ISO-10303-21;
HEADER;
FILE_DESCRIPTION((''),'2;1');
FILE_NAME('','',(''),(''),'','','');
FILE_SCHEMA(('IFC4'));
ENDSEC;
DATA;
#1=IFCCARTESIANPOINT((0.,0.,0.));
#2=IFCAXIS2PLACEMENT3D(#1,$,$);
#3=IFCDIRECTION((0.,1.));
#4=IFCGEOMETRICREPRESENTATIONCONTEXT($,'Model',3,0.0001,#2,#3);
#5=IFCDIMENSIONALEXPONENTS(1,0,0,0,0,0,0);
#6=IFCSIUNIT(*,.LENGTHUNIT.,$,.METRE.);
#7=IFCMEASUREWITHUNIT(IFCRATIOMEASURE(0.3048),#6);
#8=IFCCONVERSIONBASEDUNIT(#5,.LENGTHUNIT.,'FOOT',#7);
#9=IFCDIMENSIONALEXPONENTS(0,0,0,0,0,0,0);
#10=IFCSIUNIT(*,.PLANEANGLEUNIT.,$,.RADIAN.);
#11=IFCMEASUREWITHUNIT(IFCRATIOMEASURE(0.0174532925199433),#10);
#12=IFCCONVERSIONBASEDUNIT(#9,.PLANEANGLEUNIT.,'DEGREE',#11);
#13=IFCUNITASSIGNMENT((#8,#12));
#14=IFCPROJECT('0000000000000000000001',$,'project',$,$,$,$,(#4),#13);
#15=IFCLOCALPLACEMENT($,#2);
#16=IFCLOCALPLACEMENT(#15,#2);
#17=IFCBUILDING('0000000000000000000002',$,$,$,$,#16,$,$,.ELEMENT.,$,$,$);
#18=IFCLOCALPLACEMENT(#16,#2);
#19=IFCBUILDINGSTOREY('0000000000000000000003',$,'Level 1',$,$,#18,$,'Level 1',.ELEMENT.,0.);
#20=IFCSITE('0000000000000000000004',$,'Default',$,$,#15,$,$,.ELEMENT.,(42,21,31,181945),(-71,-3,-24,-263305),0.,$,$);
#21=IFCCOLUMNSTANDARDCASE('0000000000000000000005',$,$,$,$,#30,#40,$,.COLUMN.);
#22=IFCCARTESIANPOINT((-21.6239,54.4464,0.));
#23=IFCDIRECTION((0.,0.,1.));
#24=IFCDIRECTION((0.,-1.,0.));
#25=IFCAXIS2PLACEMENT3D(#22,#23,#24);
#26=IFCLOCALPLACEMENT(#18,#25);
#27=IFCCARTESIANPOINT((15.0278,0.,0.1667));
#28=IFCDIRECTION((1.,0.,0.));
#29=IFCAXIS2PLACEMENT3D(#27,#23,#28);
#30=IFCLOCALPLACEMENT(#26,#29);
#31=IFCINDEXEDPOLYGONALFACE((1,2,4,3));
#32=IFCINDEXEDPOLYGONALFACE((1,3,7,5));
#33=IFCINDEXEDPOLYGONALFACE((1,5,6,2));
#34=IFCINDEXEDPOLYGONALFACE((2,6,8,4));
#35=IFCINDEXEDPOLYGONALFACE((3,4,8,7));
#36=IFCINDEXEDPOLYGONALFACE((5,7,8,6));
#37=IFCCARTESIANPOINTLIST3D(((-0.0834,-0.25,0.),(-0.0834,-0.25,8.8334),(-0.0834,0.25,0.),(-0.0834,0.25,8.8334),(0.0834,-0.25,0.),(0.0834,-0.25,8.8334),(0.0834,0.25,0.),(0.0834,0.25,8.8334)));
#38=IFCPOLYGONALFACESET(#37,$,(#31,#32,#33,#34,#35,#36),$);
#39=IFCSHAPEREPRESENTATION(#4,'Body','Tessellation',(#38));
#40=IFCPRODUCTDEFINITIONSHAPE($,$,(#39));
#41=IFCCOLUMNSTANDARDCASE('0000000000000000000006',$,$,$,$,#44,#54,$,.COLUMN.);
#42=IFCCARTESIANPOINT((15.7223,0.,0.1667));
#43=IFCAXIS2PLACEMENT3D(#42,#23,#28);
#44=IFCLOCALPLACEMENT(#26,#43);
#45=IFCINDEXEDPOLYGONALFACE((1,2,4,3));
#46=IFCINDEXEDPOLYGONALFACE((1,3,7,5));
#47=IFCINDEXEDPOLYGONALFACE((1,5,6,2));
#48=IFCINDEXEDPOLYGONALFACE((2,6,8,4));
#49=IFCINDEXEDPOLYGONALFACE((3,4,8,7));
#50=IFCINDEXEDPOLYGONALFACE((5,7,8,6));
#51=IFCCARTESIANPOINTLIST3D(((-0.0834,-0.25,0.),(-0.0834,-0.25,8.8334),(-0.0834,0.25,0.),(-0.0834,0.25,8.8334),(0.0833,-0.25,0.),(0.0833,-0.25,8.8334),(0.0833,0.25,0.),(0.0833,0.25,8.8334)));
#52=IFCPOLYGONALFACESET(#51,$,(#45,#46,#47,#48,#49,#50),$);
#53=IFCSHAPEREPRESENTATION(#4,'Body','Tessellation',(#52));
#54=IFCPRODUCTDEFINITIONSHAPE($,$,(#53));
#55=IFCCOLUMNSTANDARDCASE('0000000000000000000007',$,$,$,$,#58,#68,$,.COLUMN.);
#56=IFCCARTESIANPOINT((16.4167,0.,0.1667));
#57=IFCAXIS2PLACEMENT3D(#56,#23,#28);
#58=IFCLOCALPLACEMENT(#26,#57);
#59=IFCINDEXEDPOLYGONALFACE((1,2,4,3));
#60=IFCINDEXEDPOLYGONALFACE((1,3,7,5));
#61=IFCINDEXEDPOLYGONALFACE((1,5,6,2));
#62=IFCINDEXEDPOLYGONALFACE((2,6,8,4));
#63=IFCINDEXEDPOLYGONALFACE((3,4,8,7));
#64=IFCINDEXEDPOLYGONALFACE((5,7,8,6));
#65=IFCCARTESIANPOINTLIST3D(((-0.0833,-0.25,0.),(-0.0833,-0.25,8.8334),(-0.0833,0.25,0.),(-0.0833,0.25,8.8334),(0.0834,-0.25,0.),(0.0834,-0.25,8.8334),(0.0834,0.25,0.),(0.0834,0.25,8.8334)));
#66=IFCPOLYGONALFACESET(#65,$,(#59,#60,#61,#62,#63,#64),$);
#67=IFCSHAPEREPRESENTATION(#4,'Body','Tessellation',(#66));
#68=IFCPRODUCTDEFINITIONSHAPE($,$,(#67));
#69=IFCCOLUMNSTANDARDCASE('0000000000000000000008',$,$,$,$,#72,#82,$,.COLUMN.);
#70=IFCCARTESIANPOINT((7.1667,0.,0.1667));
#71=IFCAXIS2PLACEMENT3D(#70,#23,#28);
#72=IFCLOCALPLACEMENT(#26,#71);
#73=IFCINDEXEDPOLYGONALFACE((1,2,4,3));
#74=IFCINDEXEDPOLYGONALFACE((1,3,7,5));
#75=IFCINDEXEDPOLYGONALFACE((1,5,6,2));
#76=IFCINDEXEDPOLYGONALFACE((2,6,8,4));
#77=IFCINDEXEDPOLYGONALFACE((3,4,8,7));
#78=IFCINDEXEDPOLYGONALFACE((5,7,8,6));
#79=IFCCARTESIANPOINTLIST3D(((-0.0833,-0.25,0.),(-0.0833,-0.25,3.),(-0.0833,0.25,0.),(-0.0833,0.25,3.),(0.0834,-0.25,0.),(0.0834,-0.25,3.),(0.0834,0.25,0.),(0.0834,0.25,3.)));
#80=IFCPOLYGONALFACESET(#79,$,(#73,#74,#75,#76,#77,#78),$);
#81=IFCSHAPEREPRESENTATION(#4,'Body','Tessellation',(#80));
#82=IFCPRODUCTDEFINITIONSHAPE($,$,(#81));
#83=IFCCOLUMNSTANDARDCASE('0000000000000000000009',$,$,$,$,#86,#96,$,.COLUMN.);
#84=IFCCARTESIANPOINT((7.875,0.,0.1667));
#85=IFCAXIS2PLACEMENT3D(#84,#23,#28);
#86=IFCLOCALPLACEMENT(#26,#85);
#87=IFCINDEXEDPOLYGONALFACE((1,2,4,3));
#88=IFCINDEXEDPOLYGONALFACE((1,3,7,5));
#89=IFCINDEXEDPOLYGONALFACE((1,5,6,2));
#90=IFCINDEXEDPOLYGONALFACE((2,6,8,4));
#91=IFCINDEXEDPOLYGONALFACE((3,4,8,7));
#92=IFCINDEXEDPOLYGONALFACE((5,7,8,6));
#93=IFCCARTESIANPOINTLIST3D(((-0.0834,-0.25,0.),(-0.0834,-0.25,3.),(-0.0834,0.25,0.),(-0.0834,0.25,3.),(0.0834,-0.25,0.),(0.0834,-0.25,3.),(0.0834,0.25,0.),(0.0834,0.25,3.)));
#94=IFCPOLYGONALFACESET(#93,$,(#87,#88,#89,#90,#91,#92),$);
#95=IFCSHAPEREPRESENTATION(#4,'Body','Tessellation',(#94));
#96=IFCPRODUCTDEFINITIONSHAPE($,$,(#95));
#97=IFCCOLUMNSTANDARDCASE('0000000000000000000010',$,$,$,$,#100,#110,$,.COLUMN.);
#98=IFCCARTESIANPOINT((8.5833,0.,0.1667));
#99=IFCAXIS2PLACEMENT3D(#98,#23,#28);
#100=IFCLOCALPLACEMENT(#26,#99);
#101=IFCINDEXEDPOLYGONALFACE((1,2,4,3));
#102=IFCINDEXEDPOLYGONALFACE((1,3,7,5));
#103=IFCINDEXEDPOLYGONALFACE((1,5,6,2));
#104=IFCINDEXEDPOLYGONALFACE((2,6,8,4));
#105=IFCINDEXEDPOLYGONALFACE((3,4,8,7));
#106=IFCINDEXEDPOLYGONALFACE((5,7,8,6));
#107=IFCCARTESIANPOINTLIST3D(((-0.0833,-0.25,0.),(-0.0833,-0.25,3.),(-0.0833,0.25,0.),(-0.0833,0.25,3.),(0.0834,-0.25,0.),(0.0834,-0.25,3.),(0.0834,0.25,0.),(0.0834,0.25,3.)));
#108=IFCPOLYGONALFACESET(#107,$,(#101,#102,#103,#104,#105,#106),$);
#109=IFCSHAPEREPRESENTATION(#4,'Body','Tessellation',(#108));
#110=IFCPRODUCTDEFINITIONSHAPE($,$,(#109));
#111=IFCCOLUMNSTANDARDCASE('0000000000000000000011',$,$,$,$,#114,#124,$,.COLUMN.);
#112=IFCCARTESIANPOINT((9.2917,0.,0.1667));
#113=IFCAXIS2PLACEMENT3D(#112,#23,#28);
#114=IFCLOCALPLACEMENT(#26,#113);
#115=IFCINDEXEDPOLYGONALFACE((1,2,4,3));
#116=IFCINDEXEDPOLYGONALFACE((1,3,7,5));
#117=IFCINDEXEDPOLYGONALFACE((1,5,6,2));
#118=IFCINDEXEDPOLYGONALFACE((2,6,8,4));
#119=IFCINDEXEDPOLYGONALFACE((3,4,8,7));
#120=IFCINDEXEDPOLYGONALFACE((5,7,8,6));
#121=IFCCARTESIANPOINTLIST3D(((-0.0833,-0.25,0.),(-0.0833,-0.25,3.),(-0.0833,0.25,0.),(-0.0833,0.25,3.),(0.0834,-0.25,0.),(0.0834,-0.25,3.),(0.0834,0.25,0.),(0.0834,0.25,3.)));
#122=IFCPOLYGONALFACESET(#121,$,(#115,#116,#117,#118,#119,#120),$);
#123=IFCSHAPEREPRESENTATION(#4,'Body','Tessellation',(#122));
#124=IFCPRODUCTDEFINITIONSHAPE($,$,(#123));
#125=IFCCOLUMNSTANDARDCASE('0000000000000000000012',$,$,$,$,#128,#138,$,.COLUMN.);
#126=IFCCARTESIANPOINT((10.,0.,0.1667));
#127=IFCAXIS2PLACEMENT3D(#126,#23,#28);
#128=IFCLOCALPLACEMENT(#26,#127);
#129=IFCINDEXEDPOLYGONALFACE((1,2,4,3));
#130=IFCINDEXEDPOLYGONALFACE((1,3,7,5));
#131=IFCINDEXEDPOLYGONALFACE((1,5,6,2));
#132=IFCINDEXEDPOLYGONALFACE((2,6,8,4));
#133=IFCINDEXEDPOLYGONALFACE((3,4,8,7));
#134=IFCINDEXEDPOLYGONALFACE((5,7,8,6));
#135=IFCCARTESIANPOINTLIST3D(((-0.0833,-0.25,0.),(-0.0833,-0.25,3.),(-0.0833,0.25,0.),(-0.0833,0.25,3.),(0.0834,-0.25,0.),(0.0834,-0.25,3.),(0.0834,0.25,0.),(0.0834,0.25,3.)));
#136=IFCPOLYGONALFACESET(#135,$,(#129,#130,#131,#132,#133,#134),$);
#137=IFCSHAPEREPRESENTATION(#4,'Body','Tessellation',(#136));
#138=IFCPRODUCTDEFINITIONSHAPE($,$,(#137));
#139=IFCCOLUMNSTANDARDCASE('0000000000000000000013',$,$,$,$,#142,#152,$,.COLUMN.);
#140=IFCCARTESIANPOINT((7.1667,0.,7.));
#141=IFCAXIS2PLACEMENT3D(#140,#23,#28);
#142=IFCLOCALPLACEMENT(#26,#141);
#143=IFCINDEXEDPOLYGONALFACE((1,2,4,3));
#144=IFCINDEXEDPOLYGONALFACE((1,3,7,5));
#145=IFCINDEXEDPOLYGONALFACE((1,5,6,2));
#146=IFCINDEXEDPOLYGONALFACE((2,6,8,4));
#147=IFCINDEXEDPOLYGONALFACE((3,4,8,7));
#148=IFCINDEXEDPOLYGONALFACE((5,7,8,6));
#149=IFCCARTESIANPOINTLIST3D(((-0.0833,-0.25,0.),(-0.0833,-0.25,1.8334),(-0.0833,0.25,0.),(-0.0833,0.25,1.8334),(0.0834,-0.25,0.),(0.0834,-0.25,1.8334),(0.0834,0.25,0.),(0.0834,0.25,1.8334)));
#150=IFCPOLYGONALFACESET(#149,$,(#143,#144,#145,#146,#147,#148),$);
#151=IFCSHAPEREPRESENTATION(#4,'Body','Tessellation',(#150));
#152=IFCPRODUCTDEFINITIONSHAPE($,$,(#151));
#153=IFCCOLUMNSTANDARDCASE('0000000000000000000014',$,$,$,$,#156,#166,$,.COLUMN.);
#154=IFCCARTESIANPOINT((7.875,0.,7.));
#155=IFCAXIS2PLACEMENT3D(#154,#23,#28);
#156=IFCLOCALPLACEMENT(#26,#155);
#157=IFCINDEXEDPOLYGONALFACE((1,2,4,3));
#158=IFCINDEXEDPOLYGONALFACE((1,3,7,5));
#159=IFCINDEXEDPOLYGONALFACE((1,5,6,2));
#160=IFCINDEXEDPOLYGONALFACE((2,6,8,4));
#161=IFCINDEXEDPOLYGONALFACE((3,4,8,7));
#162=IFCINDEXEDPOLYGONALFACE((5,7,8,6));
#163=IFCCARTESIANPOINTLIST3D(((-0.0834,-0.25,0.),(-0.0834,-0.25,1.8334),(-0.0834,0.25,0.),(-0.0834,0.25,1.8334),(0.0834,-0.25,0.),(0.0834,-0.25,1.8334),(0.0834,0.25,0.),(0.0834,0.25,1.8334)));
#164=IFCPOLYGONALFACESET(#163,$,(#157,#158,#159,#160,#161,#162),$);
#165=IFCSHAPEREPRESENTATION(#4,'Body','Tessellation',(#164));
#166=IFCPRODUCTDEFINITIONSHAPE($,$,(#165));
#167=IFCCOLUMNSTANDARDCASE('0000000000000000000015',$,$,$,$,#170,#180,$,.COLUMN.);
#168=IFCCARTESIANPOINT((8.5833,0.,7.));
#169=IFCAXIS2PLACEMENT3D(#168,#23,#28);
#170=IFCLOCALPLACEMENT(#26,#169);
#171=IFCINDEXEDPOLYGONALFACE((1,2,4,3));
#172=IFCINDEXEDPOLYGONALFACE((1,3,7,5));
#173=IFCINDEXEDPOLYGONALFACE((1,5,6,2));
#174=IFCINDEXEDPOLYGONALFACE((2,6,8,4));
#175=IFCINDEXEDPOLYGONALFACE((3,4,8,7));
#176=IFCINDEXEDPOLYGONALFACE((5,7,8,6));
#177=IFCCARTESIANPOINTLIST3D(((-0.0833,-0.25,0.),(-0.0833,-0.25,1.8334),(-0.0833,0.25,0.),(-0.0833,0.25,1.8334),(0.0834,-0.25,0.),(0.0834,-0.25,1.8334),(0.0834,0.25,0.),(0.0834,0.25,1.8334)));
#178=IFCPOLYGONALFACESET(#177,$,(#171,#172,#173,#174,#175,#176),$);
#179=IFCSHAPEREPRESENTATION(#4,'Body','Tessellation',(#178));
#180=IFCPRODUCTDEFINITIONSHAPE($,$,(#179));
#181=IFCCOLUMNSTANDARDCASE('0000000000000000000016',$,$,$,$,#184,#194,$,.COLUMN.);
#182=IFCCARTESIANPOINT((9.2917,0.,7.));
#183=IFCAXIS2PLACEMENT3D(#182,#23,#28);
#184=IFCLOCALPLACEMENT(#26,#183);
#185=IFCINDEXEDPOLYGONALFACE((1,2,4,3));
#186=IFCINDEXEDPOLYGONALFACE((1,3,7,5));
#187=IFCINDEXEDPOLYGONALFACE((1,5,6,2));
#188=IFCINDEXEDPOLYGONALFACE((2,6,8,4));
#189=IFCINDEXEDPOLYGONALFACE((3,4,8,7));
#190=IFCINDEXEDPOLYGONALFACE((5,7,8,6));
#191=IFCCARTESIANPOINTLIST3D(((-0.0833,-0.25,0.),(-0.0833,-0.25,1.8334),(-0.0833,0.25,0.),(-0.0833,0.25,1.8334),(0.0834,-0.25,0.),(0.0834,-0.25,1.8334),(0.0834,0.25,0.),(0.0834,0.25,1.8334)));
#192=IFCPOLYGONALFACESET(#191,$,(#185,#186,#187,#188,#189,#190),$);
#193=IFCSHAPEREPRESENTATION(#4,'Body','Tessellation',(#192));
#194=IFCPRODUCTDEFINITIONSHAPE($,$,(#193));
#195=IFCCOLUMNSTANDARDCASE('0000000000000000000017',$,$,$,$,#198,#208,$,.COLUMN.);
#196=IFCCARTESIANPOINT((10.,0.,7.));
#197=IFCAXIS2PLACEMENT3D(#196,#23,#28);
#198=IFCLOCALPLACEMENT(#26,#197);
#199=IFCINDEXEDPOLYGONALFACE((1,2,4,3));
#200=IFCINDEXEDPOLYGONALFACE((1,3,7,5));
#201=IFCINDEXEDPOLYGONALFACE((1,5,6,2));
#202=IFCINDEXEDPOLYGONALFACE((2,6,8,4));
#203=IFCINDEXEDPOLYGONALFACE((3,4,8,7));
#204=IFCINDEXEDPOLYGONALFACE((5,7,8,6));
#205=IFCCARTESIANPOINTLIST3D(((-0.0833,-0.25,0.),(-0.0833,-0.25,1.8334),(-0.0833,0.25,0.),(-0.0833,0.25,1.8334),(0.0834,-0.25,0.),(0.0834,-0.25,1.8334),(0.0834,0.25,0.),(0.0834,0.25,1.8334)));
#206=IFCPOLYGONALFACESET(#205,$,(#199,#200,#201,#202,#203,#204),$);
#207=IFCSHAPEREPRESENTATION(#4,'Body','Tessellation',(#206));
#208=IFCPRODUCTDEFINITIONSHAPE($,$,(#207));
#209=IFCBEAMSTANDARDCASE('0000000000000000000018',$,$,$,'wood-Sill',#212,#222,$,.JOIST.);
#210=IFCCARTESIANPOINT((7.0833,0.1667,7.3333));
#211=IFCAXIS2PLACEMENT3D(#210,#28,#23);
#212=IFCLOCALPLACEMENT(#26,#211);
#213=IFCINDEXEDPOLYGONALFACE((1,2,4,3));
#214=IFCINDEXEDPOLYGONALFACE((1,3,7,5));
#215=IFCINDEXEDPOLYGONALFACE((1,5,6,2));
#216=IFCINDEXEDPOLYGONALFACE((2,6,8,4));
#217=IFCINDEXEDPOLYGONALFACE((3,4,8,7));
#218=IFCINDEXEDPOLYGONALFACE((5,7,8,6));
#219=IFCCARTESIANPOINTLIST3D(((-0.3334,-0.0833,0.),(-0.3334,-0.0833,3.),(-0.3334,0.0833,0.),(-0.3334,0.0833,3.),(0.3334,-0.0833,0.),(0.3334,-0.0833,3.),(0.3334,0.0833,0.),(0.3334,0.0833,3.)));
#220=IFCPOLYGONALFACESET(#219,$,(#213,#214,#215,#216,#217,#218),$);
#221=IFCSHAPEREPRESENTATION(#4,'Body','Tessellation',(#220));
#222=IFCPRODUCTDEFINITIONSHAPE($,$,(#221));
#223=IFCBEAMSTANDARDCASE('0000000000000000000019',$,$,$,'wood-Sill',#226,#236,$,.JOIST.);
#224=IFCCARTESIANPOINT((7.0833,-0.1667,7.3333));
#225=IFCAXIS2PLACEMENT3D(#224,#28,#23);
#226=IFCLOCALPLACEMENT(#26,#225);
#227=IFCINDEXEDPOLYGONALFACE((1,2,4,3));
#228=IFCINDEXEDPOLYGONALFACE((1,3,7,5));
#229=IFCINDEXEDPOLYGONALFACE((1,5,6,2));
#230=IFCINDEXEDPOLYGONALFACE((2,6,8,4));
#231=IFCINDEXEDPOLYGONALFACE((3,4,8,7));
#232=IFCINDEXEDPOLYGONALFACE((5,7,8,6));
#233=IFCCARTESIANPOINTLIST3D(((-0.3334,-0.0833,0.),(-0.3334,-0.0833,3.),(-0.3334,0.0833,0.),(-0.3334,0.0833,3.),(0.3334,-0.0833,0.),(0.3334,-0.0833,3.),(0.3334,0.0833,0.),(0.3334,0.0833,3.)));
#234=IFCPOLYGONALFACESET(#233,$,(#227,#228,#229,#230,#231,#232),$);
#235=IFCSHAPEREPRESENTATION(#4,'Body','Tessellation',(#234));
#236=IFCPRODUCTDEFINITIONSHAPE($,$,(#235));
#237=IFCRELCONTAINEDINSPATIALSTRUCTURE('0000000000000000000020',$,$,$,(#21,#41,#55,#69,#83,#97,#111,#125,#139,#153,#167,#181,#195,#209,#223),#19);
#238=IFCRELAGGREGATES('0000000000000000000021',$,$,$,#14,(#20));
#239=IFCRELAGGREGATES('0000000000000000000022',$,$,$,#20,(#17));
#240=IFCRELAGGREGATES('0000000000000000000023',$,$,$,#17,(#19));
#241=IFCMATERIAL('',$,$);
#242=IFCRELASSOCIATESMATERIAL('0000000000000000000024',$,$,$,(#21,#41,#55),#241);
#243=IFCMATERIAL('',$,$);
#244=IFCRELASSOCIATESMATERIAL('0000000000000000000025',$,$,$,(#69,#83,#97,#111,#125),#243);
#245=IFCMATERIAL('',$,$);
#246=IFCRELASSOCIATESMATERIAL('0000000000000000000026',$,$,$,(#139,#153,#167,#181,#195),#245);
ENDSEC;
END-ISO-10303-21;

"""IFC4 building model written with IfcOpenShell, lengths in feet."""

from ifc_helpers import new_model, entity, si_unit, converted_unit, direction, frame, origin, origin_with_axes, place, context, project, spatial, rectangle, extrude, material, element, save


model = new_model("IFC4")

# Units and contexts
model_context = context("Model", 3, precision=0.0001, world=origin(), true_north=direction((0.0, 1.0)))
ifc_project = project(units=[converted_unit("LENGTHUNIT", "FOOT", entity("IfcRatioMeasure", 0.3048), si_unit("LENGTHUNIT", "METRE"), dimensions=[1, 0, 0, 0, 0, 0, 0]), converted_unit("PLANEANGLEUNIT", "DEGREE", entity("IfcRatioMeasure", 0.0174532925199433), si_unit("PLANEANGLEUNIT", "RADIAN"), dimensions=[0, 0, 0, 0, 0, 0, 0])], contexts=[model_context])

# Site, building, storey
site_placement = place(None, origin())
site = spatial("IfcSite", under=ifc_project, at=site_placement, Name="Default", CompositionType="ELEMENT", RefLatitude=(42, 21, 31, 181945), RefLongitude=(-71, -3, -24, -263305), RefElevation=0.0)
building_placement = place(site_placement, origin())
building = spatial("IfcBuilding", under=site, at=building_placement, CompositionType="ELEMENT")
storey_placement = place(building_placement, origin())
storey = spatial("IfcBuildingStorey", under=building, at=storey_placement, Name="Level 1", LongName="Level 1", CompositionType="ELEMENT", Elevation=0.0)

# Columns
placement_1 = place(storey_placement, frame((-21.6239, 54.4464, 0.0), z_axis=(0.0, 0.0, 1.0), x_axis=(0.0, -1.0, 0.0)))
ifc_material_1 = material(Name="")
for number, where, z_axis, x_axis in (
    (1, (15.0278, 0.0, 0.1667), (0.0, 0.0, 1.0), (1.0, 0.0, 0.0)),
    (2, (15.7223, 0.0, 0.1667), (0.0, 0.0, 1.0), (1.0, 0.0, 0.0)),
    (3, (16.4167, 0.0, 0.1667), (0.0, 0.0, 1.0), (1.0, 0.0, 0.0)),
):
    element("IfcColumnStandardCase", number, at=place(placement_1, frame(where, z_axis=z_axis, x_axis=x_axis)), inside=storey, material=ifc_material_1, PredefinedType="COLUMN", context=model_context, shape_type="SweptSolid", body=[
        extrude(rectangle(XDim=0.1667, YDim=0.5), origin(), (0.0, 0.0, 1.0), 8.8334),
    ])
ifc_material_2 = material(Name="")
for number, where, z_axis, x_axis in (
    (4, (7.1667, 0.0, 0.1667), (0.0, 0.0, 1.0), (1.0, 0.0, 0.0)),
    (5, (7.875, 0.0, 0.1667), (0.0, 0.0, 1.0), (1.0, 0.0, 0.0)),
    (6, (8.5833, 0.0, 0.1667), (0.0, 0.0, 1.0), (1.0, 0.0, 0.0)),
    (7, (9.2917, 0.0, 0.1667), (0.0, 0.0, 1.0), (1.0, 0.0, 0.0)),
    (8, (10.0, 0.0, 0.1667), (0.0, 0.0, 1.0), (1.0, 0.0, 0.0)),
):
    element("IfcColumnStandardCase", number, at=place(placement_1, frame(where, z_axis=z_axis, x_axis=x_axis)), inside=storey, material=ifc_material_2, PredefinedType="COLUMN", context=model_context, shape_type="SweptSolid", body=[
        extrude(rectangle(XDim=0.1667, YDim=0.5), origin(), (0.0, 0.0, 1.0), 3.0),
    ])
ifc_material_3 = material(Name="")
for number, where, z_axis, x_axis in (
    (9, (7.1667, 0.0, 7.0), (0.0, 0.0, 1.0), (1.0, 0.0, 0.0)),
    (10, (7.875, 0.0, 7.0), (0.0, 0.0, 1.0), (1.0, 0.0, 0.0)),
    (11, (8.5833, 0.0, 7.0), (0.0, 0.0, 1.0), (1.0, 0.0, 0.0)),
    (12, (9.2917, 0.0, 7.0), (0.0, 0.0, 1.0), (1.0, 0.0, 0.0)),
    (13, (10.0, 0.0, 7.0), (0.0, 0.0, 1.0), (1.0, 0.0, 0.0)),
):
    element("IfcColumnStandardCase", number, at=place(placement_1, frame(where, z_axis=z_axis, x_axis=x_axis)), inside=storey, material=ifc_material_3, PredefinedType="COLUMN", context=model_context, shape_type="SweptSolid", body=[
        extrude(rectangle(XDim=0.1667, YDim=0.5), origin(), (0.0, 0.0, 1.0), 1.8334),
    ])

# Beams
for number, where, z_axis, x_axis in (
    (14, (7.0833, 0.1667, 7.3333), (1.0, 0.0, 0.0), (0.0, 0.0, 1.0)),
    (15, (7.0833, -0.1667, 7.3333), (1.0, 0.0, 0.0), (0.0, 0.0, 1.0)),
):
    element("IfcBeamStandardCase", number, at=place(placement_1, frame(where, z_axis=z_axis, x_axis=x_axis)), inside=storey, ObjectType="wood-Sill", PredefinedType="JOIST", context=model_context, shape_type="SweptSolid", body=[
        extrude(rectangle(XDim=0.6667, YDim=0.1667), origin_with_axes(), (0.0, 0.0, 1.0), 3.0),
    ])

save(model, "model.ifc")
